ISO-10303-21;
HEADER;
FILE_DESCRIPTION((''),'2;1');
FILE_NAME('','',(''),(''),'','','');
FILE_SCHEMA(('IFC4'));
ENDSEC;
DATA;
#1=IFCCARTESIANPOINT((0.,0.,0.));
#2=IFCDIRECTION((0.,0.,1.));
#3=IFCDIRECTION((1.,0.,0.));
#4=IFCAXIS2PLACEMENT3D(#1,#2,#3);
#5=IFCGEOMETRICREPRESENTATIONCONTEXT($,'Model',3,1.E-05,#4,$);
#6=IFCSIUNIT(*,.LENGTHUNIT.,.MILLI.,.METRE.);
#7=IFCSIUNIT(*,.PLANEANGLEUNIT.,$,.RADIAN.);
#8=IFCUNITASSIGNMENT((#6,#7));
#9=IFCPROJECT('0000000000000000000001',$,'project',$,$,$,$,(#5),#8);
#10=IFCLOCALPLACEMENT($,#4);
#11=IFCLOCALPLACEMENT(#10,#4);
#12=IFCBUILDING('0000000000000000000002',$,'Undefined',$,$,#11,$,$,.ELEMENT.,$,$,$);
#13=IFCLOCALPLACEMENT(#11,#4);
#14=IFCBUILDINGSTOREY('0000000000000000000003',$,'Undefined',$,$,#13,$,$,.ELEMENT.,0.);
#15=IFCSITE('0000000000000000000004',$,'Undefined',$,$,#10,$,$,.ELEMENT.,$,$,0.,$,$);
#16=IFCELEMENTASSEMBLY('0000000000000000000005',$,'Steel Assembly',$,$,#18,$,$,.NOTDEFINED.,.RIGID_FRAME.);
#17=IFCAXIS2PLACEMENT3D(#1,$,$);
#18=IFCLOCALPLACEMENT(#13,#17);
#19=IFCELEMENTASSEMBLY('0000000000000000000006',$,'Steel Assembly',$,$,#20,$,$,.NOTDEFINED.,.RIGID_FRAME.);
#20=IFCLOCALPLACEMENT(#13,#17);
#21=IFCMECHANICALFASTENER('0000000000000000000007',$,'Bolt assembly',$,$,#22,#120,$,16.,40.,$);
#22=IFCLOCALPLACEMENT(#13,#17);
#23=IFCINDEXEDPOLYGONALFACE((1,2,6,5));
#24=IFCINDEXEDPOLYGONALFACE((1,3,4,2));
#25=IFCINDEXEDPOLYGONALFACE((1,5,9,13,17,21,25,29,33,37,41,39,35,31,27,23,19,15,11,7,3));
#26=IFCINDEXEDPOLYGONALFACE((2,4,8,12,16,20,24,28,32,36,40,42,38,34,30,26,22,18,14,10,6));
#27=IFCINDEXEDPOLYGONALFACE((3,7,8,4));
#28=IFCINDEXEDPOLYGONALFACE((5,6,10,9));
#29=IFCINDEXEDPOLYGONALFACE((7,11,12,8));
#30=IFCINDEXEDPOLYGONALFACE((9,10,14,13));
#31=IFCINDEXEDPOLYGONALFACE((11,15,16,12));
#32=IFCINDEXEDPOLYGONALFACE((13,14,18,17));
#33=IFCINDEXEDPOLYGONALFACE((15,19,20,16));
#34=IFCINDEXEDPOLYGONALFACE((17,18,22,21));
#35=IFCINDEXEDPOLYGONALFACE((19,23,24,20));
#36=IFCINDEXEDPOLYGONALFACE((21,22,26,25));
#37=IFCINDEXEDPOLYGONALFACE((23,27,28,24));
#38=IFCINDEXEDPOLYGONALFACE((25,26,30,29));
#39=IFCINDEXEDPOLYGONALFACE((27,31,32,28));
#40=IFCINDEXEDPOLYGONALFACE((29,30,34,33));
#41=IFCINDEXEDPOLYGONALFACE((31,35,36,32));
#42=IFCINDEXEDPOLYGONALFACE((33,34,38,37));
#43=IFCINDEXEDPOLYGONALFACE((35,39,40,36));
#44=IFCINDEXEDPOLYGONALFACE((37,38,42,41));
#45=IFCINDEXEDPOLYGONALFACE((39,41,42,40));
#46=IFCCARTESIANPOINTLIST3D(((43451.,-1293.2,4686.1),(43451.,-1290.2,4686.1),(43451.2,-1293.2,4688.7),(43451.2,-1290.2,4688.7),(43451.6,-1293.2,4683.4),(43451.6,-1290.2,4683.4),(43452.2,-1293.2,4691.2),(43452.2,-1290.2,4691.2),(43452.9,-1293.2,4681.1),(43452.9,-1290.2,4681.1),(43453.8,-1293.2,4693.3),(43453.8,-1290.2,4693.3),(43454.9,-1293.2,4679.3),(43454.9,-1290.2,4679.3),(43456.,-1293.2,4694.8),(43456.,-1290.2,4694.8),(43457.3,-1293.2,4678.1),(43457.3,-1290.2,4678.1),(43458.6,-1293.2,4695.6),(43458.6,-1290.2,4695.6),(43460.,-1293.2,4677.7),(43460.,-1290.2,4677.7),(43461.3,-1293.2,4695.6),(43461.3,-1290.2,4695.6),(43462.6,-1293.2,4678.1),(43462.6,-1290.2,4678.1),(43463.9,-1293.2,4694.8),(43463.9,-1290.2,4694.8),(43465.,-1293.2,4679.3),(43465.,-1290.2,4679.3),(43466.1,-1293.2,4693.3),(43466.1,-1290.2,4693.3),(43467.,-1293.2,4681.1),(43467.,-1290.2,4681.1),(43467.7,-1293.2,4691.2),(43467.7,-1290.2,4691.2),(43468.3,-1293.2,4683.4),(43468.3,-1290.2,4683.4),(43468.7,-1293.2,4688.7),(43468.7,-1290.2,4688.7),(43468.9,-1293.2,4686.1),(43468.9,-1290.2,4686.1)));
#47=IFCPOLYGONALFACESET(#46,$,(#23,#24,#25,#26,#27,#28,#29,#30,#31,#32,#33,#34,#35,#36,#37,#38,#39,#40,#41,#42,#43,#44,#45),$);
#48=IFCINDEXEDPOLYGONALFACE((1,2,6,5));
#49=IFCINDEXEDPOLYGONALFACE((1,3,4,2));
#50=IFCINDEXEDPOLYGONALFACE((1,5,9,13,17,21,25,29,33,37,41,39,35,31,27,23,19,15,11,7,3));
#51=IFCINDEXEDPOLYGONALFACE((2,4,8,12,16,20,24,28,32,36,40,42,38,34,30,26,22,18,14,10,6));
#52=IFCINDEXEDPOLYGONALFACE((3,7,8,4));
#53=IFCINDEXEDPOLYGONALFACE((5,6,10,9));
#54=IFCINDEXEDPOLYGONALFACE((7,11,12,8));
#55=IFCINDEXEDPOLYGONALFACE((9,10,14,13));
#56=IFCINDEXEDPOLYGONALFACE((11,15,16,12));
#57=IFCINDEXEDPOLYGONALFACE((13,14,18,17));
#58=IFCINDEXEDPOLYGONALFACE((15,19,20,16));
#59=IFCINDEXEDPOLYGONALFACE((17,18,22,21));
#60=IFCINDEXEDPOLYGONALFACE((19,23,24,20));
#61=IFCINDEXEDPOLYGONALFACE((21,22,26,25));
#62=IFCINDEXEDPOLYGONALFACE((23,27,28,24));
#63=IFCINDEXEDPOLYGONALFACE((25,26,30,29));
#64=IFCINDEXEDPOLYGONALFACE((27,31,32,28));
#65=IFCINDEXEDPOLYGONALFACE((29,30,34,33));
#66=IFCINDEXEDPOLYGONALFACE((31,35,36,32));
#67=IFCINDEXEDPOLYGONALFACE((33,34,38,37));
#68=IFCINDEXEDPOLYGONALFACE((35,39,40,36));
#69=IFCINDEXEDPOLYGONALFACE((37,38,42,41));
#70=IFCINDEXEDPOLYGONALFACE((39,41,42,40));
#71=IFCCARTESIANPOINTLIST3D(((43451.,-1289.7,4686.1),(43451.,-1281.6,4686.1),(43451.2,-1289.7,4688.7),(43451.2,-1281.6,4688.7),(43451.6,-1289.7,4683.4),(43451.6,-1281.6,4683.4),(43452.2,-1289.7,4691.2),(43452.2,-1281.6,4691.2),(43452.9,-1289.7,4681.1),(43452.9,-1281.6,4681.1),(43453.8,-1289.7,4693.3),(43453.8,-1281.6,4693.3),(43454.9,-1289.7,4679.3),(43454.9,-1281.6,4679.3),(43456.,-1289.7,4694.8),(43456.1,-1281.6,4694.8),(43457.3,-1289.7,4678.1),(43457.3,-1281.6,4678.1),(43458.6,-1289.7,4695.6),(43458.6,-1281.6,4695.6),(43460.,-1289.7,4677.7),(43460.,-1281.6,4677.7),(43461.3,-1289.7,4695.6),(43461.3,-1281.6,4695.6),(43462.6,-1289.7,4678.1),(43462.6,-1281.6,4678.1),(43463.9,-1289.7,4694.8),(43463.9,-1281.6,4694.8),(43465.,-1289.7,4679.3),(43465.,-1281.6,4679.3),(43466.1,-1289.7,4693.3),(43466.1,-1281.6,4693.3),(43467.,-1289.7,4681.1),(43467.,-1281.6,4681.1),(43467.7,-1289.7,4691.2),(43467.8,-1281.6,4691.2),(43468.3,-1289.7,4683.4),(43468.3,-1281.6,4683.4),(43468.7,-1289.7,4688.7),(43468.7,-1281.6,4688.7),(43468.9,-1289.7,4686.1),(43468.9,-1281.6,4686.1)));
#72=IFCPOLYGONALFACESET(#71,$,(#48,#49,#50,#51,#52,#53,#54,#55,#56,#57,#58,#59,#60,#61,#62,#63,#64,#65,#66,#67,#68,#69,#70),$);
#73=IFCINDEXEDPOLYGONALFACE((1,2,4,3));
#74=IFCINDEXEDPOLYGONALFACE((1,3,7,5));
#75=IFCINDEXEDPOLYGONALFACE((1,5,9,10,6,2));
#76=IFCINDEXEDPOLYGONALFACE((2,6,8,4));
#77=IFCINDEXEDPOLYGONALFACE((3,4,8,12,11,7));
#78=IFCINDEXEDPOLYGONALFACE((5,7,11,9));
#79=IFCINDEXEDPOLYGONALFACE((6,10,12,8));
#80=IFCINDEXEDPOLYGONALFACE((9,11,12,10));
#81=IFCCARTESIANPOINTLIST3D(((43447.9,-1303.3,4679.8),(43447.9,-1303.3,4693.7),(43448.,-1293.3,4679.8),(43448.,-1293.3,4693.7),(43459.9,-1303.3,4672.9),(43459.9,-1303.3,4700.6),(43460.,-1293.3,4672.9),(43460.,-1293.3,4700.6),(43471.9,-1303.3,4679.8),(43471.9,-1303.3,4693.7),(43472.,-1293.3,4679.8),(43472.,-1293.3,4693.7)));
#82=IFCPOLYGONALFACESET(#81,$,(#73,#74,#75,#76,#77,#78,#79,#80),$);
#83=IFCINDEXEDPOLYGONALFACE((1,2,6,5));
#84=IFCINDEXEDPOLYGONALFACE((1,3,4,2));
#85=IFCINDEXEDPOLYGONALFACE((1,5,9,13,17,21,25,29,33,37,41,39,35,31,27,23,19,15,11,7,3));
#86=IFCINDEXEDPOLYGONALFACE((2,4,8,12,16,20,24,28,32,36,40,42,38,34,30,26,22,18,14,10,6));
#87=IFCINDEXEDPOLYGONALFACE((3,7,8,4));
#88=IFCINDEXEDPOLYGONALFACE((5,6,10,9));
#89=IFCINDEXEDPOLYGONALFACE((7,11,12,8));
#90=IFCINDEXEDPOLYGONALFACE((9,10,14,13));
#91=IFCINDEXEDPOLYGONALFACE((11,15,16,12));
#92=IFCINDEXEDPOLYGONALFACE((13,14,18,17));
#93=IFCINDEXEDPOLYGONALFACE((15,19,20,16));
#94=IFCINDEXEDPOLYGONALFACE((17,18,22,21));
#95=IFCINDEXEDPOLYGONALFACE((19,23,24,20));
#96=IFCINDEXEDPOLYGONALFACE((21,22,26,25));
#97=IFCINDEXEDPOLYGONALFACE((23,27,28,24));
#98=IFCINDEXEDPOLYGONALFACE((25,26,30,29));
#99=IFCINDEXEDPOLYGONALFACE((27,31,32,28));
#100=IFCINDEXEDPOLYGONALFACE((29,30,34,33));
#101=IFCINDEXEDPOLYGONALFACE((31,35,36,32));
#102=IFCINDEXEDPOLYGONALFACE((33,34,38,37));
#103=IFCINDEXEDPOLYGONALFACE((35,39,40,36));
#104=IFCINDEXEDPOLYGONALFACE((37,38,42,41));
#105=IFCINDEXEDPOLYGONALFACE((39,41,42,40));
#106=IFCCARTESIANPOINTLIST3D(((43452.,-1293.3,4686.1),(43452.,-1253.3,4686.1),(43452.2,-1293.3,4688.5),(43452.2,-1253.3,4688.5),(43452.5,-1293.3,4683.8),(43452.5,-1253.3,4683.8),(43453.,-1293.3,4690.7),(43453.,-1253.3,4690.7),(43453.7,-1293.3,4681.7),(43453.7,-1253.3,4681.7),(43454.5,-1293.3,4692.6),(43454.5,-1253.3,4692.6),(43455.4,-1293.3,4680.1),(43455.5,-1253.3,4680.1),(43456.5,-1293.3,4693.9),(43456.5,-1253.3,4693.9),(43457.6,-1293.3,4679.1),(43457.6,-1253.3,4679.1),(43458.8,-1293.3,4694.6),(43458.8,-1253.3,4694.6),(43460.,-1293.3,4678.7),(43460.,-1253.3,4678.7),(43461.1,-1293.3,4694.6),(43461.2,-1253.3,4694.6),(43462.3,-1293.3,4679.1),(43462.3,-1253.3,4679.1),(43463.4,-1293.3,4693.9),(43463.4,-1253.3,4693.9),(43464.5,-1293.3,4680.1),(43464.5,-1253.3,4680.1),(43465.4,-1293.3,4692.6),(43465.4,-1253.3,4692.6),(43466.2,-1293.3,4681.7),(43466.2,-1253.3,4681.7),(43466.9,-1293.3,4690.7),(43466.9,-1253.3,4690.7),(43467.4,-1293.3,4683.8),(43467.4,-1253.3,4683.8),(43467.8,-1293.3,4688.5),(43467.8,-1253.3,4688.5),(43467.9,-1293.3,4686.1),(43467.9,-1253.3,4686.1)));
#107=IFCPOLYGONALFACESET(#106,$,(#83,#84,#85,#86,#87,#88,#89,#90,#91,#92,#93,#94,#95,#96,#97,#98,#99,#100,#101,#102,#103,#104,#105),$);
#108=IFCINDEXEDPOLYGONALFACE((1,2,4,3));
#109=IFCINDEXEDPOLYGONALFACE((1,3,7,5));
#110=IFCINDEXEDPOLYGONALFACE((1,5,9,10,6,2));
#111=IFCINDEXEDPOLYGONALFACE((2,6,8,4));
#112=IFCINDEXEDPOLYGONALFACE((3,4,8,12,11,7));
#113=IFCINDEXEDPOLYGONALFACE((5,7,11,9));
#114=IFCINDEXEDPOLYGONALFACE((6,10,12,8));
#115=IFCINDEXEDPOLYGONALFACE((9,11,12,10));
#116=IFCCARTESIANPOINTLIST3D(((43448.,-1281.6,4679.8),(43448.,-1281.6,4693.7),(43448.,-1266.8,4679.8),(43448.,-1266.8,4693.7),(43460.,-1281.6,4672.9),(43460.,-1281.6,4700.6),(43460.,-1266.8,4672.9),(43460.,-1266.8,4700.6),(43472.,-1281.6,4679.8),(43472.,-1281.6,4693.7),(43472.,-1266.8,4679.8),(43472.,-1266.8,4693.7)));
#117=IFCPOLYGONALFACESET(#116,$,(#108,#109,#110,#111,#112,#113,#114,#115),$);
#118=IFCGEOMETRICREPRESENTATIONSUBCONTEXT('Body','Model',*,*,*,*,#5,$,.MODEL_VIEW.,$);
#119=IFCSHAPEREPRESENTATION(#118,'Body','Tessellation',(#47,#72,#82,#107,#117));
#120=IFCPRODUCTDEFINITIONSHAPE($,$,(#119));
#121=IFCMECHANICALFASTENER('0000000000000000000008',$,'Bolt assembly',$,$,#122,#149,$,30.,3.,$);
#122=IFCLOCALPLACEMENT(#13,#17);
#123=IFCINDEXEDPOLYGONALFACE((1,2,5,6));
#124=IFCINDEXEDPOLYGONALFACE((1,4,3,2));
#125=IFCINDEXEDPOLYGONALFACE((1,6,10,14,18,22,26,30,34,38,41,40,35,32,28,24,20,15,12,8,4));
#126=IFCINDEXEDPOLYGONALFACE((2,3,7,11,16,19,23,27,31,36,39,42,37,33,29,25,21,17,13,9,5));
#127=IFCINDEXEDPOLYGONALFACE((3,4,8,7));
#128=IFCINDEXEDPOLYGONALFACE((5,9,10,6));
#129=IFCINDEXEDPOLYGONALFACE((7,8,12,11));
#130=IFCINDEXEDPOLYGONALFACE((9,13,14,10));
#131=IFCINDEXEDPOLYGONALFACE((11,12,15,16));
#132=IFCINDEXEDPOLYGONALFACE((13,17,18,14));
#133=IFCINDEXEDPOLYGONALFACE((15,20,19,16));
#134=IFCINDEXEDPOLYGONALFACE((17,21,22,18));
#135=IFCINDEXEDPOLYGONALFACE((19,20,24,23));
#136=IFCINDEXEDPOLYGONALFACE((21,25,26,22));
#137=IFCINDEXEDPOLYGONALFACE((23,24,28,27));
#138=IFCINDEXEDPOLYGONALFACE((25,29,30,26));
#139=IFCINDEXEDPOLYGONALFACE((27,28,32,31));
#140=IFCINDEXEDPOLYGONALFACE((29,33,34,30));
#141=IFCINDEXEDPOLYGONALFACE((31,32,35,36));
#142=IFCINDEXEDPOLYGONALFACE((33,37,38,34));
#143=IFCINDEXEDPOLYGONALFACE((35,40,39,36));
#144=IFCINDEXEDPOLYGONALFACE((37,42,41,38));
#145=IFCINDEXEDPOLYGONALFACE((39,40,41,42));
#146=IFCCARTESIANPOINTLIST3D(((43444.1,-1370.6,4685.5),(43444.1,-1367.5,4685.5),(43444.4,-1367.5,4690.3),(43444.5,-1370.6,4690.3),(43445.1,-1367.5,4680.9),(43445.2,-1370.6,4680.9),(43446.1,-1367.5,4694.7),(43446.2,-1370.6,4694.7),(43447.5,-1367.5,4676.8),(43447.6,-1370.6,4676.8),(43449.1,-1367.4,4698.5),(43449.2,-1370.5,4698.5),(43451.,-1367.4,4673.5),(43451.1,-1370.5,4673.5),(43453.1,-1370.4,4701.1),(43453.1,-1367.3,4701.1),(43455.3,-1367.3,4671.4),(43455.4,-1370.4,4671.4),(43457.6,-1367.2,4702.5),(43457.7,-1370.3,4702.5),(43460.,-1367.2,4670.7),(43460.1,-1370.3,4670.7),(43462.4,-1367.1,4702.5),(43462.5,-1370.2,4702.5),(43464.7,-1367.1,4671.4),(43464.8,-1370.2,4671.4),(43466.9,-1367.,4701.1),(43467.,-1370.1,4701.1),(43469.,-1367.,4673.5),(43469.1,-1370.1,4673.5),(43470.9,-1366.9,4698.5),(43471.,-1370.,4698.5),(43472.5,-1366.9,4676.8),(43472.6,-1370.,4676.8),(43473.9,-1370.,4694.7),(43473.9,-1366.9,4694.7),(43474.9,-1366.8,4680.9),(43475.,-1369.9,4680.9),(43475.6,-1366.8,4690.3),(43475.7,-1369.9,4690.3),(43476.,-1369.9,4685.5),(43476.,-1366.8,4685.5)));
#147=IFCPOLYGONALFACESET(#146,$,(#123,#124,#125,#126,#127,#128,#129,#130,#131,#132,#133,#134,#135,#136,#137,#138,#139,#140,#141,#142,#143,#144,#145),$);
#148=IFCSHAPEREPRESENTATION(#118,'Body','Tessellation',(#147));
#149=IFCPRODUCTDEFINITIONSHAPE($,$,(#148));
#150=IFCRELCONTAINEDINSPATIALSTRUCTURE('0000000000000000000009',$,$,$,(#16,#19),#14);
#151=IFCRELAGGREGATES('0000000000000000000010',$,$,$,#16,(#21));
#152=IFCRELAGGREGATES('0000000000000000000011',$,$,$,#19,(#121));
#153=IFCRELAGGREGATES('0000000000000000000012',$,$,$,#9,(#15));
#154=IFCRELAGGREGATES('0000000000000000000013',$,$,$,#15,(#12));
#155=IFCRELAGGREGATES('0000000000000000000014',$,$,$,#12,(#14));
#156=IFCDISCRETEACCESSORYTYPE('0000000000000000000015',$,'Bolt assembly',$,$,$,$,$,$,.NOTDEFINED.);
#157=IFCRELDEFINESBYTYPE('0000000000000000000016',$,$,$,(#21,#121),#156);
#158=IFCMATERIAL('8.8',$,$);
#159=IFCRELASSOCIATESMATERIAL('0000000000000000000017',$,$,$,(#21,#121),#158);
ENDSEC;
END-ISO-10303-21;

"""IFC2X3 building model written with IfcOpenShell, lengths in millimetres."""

from ifc_helpers import new_model, si_unit, frame, origin_with_axes, origin_2d_with_axis, place, context, subcontext, project, spatial, polyline, circle, outline, extrude, source, transform, mapped, material, type_object, element, aggregate, save


model = new_model("IFC2X3")

# Units and contexts
model_context = context("Model", 3, precision=1e-05, world=origin_with_axes())
body_context = subcontext(model_context, "Body", "Model", "MODEL_VIEW")
ifc_project = project(units=[si_unit("LENGTHUNIT", "METRE", prefix="MILLI"), si_unit("PLANEANGLEUNIT", "RADIAN")], contexts=[model_context])

# Site, building, storey
site_placement = place(None, origin_with_axes())
site = spatial("IfcSite", under=ifc_project, at=site_placement, Name="Undefined", CompositionType="ELEMENT", RefElevation=0.0)
building_placement = place(site_placement, origin_with_axes())
building = spatial("IfcBuilding", under=site, at=building_placement, Name="Undefined", CompositionType="ELEMENT")
storey_placement = place(building_placement, origin_with_axes())
storey = spatial("IfcBuildingStorey", under=building, at=storey_placement, Name="Undefined", CompositionType="ELEMENT", Elevation=0.0)

# Element assembly
assembly_1_placement = place(storey_placement, origin_with_axes())
assembly_1 = element("IfcElementAssembly", 1, at=assembly_1_placement, inside=storey, Name="Steel Assembly", AssemblyPlace="NOTDEFINED", PredefinedType="RIGID_FRAME")

# Element assembly
assembly_2_placement = place(storey_placement, origin_with_axes())
assembly_2 = element("IfcElementAssembly", 2, at=assembly_2_placement, inside=storey, Name="Steel Assembly", AssemblyPlace="NOTDEFINED", PredefinedType="RIGID_FRAME")

# Shared definitions
discrete_accessory_type_1 = type_object("IfcDiscreteAccessoryType", Name="Bolt assembly")

# Shared definitions
ifc_material_1 = material(Name="8.8")

# Mechanical fasteners
shared_shape_1 = source(origin_with_axes(), body_context, "Body", "SweptSolid", [
    extrude(circle(Radius=9.0, at=origin_2d_with_axis()), frame((0.0, -8.0, 0.0), z_axis=(0.0, 1.0, 0.0), x_axis=(1.0, 0.0, 0.0)), (0.0, 0.0, 1.0), 3.0),
    extrude(circle(Radius=9.0, at=origin_2d_with_axis()), frame((0.0, -4.6, 0.0), z_axis=(0.0, 1.0, 0.0), x_axis=(1.0, 0.0, 0.0)), (0.0, 0.0, 1.0), 8.1),
    extrude(outline(polyline([(13.9, 0.0), (6.9, 12.0), (-6.9, 12.0), (-13.9, 0.0), (-6.9, -12.0), (6.9, -12.0), (13.9, 0.0)])), frame((0.0, -18.1, 0.0), z_axis=(0.0, 1.0, 0.0), x_axis=(1.0, 0.0, 0.0)), (0.0, 0.0, 1.0), 10.0),
    extrude(circle(Radius=8.0, at=origin_2d_with_axis()), frame((0.0, -8.1, 0.0), z_axis=(0.0, 1.0, 0.0), x_axis=(1.0, 0.0, 0.0)), (0.0, 0.0, 1.0), 40.0),
    extrude(outline(polyline([(13.9, 0.0), (6.9, 12.0), (-6.9, 12.0), (-13.9, 0.0), (-6.9, -12.0), (6.9, -12.0), (13.9, 0.0)])), frame((0.0, 3.5, 0.0), z_axis=(0.0, 1.0, 0.0), x_axis=(1.0, 0.0, 0.0)), (0.0, 0.0, 1.0), 14.8),
])
mechanical_fastener_1_placement = place(assembly_1_placement, frame((43460.0, -1285.1, 4686.7), z_axis=(1.0, -0.000419, 0.0), x_axis=(0.0, -0.000007, -1.0)))
mechanical_fastener_1 = element("IfcMechanicalFastener", 3, at=mechanical_fastener_1_placement, type_object=discrete_accessory_type_1, material=ifc_material_1, Name="Bolt assembly", NominalDiameter=16.0, NominalLength=40.0, context=body_context, shape_type="MappedRepresentation", body=[
    mapped(shared_shape_1, transform((0.0, 0.0, 0.0))),
])
aggregate(assembly_1, [mechanical_fastener_1])
shared_shape_2 = source(origin_with_axes(), body_context, "Body", "SweptSolid", [
    extrude(circle(Radius=16.0, at=origin_2d_with_axis()), frame((0.0, -5.2, 0.0), z_axis=(0.0, 1.0, 0.0), x_axis=(1.0, 0.0, 0.0)), (0.0, 0.0, 1.0), 3.1),
])
mechanical_fastener_2_placement = place(assembly_2_placement, frame((43460.0, -1365.1, 4686.7), z_axis=(0.999745, 0.022588, 0.0), x_axis=(0.0, -0.000007, -1.0)))
mechanical_fastener_2 = element("IfcMechanicalFastener", 4, at=mechanical_fastener_2_placement, type_object=discrete_accessory_type_1, material=ifc_material_1, Name="Bolt assembly", NominalDiameter=30.0, NominalLength=3.0, context=body_context, shape_type="MappedRepresentation", body=[
    mapped(shared_shape_2, transform((0.0, 0.0, 0.0))),
])
aggregate(assembly_2, [mechanical_fastener_2])

save(model, "model.ifc")
